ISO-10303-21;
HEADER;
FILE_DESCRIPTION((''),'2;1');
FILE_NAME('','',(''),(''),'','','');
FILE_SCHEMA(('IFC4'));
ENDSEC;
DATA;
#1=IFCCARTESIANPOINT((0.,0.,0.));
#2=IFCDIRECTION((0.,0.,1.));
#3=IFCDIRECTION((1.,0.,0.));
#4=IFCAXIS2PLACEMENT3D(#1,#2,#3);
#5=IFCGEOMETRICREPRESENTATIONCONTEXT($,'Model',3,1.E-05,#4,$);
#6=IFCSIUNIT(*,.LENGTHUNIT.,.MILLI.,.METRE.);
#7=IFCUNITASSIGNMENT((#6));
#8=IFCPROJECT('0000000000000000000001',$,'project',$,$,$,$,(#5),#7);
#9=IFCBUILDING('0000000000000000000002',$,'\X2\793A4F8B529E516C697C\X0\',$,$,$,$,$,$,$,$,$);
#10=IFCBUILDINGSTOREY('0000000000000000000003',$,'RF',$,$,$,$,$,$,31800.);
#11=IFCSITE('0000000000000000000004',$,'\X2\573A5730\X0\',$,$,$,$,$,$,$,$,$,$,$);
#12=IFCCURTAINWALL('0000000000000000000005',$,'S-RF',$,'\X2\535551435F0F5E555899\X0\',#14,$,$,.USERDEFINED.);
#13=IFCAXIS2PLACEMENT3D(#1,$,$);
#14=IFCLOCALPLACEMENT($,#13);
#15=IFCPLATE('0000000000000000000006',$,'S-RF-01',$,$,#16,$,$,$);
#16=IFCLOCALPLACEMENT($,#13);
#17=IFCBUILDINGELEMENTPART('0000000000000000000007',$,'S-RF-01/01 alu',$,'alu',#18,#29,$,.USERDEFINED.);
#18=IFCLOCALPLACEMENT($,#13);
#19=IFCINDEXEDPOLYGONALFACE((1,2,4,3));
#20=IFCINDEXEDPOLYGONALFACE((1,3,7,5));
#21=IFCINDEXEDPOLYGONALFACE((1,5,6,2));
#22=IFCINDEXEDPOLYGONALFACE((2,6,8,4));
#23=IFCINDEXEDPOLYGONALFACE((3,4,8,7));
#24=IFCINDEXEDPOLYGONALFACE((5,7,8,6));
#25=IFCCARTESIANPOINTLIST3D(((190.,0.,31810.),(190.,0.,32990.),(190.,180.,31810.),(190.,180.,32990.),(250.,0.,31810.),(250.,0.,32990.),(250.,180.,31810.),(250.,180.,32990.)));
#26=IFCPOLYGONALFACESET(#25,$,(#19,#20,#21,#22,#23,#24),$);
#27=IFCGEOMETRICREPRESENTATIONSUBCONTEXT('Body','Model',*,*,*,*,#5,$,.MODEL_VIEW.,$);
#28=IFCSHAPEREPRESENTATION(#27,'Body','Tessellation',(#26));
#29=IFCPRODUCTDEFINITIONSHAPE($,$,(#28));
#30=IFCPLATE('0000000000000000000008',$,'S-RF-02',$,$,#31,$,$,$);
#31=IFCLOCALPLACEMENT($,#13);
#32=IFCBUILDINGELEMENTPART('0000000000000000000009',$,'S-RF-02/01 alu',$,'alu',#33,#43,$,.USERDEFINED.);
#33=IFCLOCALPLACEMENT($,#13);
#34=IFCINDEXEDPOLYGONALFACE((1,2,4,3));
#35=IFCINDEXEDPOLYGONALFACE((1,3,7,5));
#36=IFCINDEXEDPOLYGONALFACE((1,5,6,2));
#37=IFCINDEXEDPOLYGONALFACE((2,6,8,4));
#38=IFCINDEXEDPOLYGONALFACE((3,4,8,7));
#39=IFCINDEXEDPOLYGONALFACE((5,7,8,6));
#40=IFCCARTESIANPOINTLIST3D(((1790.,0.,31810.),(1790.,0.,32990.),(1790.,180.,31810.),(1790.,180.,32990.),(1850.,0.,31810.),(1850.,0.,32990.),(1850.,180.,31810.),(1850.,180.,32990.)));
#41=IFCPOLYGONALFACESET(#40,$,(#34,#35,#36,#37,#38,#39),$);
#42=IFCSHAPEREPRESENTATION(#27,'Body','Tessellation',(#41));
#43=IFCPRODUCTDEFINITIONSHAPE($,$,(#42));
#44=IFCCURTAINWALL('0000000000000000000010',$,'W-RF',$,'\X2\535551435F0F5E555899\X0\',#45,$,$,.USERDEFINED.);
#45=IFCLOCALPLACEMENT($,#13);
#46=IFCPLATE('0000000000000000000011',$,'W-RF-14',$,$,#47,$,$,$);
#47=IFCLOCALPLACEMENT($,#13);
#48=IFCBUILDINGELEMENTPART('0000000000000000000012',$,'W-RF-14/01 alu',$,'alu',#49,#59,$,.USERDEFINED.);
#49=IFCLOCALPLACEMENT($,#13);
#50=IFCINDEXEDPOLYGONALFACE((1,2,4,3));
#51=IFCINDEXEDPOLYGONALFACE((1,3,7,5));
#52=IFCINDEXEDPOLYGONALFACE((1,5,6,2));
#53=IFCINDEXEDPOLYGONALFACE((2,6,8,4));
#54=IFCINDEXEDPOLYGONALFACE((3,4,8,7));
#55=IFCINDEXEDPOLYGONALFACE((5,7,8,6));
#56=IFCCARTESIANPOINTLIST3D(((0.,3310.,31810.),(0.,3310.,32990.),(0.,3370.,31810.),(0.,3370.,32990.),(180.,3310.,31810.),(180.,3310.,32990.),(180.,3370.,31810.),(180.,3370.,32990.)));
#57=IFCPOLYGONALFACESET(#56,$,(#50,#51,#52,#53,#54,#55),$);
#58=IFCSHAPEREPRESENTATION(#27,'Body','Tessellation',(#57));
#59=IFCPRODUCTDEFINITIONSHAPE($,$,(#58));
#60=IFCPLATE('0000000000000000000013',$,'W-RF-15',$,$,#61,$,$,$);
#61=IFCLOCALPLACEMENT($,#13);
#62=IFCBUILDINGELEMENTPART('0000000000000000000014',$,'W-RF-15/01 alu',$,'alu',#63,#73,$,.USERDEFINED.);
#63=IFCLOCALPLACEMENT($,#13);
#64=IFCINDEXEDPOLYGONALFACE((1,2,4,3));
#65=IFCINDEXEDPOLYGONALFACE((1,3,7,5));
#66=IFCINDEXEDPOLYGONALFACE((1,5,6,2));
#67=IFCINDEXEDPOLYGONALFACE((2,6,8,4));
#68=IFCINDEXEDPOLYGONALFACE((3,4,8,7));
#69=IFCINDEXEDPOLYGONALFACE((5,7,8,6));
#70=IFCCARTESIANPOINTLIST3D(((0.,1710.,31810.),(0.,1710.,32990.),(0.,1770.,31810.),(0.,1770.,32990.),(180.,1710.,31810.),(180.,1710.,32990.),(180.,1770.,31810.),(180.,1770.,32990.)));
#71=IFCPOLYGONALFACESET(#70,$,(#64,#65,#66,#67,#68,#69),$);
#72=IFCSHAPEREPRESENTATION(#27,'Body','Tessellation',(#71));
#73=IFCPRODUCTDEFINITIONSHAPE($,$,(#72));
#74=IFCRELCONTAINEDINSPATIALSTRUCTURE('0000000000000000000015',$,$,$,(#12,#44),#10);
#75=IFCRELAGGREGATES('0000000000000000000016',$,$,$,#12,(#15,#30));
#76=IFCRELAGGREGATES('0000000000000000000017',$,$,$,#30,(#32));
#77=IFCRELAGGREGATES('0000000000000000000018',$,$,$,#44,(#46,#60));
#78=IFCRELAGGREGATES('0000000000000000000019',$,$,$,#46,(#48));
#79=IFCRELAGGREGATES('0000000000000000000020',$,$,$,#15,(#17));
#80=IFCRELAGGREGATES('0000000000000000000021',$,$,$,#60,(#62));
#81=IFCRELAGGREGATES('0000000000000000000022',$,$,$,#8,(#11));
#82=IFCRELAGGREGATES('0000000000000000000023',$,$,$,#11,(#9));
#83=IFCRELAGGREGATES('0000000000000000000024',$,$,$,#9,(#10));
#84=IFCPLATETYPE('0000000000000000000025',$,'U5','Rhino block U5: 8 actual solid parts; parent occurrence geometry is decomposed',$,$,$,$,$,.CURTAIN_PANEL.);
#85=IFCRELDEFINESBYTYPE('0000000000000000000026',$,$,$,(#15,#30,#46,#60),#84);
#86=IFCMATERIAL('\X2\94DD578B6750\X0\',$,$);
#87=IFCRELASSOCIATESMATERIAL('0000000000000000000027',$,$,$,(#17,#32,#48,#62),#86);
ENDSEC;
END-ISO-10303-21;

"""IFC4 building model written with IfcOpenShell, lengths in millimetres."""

from ifc_helpers import new_model, si_unit, frame, frame_2d, origin, origin_with_axes, place, context, subcontext, project, spatial, rectangle, extrude, source, transform, mapped, material, type_object, element, aggregate, save


model = new_model("IFC4")

# Units and contexts
model_context = context("Model", 3, precision=1e-05, world=origin_with_axes())
body_context = subcontext(model_context, "Body", "Model", "MODEL_VIEW")
ifc_project = project(units=[si_unit("LENGTHUNIT", "METRE", prefix="MILLI")], contexts=[model_context])

# Site, building, storey
site = spatial("IfcSite", under=ifc_project, Name="场地")
building = spatial("IfcBuilding", under=site, Name="示例办公楼")
storey = spatial("IfcBuildingStorey", under=building, Name="RF", Elevation=31800.0)

# Curtain walls, plates, building element parts
curtain_wall_1 = element("IfcCurtainWall", 1, inside=storey, Name="S-RF", ObjectType="单元式幕墙", PredefinedType="USERDEFINED")
plate_type = type_object("IfcPlateType", Name="U5", Description="Rhino block U5: 8 actual solid parts; parent occurrence geometry is decomposed", PredefinedType="CURTAIN_PANEL")
plate_1_placement = place(None, frame((190.0, 0.0, 31810.0), z_axis=(0.0, 0.0, 1.0), x_axis=(1.0, 0.0, 0.0)))
plate_1 = element("IfcPlate", 2, at=plate_1_placement, type_object=plate_type, Name="S-RF-01")
ifc_material_1 = material(Name="铝型材")
shared_shape_1 = source(origin(), body_context, "Body", "SweptSolid", [
    extrude(rectangle(XDim=60.0, YDim=180.0, at=frame_2d((30.0, 90.0))), origin(), (0.0, 0.0, 1.0), 1180.0),
])
building_element_part_1_placement = place(plate_1_placement, origin())
building_element_part_1 = element("IfcBuildingElementPart", 3, at=building_element_part_1_placement, material=ifc_material_1, Name="S-RF-01/01 alu", ObjectType="alu", PredefinedType="USERDEFINED", context=body_context, shape_type="MappedRepresentation", body=[
    mapped(shared_shape_1, transform((0.0, 0.0, 0.0))),
])
plate_2_placement = place(None, frame((1790.0, 0.0, 31810.0), z_axis=(0.0, 0.0, 1.0), x_axis=(1.0, 0.0, 0.0)))
plate_2 = element("IfcPlate", 4, at=plate_2_placement, type_object=plate_type, Name="S-RF-02")
aggregate(curtain_wall_1, [plate_1, plate_2])
building_element_part_2_placement = place(plate_2_placement, origin())
building_element_part_2 = element("IfcBuildingElementPart", 5, at=building_element_part_2_placement, material=ifc_material_1, Name="S-RF-02/01 alu", ObjectType="alu", PredefinedType="USERDEFINED", context=body_context, shape_type="MappedRepresentation", body=[
    mapped(shared_shape_1, transform((0.0, 0.0, 0.0))),
])
aggregate(plate_2, [building_element_part_2])
curtain_wall_2 = element("IfcCurtainWall", 6, inside=storey, Name="W-RF", ObjectType="单元式幕墙", PredefinedType="USERDEFINED")
plate_3_placement = place(None, frame((0.0, 3370.0, 31810.0), z_axis=(0.0, 0.0, 1.0), x_axis=(0.0, -1.0, 0.0)))
plate_3 = element("IfcPlate", 7, at=plate_3_placement, type_object=plate_type, Name="W-RF-14")
building_element_part_3_placement = place(plate_3_placement, origin())
building_element_part_3 = element("IfcBuildingElementPart", 8, at=building_element_part_3_placement, material=ifc_material_1, Name="W-RF-14/01 alu", ObjectType="alu", PredefinedType="USERDEFINED", context=body_context, shape_type="MappedRepresentation", body=[
    mapped(shared_shape_1, transform((0.0, 0.0, 0.0))),
])
plate_4_placement = place(None, frame((0.0, 1770.0, 31810.0), z_axis=(0.0, 0.0, 1.0), x_axis=(0.0, -1.0, 0.0)))
plate_4 = element("IfcPlate", 9, at=plate_4_placement, type_object=plate_type, Name="W-RF-15")
aggregate(curtain_wall_2, [plate_3, plate_4])
building_element_part_4_placement = place(plate_4_placement, origin())
building_element_part_4 = element("IfcBuildingElementPart", 10, at=building_element_part_4_placement, material=ifc_material_1, Name="W-RF-15/01 alu", ObjectType="alu", PredefinedType="USERDEFINED", context=body_context, shape_type="MappedRepresentation", body=[
    mapped(shared_shape_1, transform((0.0, 0.0, 0.0))),
])

aggregate(plate_3, [building_element_part_3])
aggregate(plate_1, [building_element_part_1])
aggregate(plate_4, [building_element_part_4])

save(model, "model.ifc")
